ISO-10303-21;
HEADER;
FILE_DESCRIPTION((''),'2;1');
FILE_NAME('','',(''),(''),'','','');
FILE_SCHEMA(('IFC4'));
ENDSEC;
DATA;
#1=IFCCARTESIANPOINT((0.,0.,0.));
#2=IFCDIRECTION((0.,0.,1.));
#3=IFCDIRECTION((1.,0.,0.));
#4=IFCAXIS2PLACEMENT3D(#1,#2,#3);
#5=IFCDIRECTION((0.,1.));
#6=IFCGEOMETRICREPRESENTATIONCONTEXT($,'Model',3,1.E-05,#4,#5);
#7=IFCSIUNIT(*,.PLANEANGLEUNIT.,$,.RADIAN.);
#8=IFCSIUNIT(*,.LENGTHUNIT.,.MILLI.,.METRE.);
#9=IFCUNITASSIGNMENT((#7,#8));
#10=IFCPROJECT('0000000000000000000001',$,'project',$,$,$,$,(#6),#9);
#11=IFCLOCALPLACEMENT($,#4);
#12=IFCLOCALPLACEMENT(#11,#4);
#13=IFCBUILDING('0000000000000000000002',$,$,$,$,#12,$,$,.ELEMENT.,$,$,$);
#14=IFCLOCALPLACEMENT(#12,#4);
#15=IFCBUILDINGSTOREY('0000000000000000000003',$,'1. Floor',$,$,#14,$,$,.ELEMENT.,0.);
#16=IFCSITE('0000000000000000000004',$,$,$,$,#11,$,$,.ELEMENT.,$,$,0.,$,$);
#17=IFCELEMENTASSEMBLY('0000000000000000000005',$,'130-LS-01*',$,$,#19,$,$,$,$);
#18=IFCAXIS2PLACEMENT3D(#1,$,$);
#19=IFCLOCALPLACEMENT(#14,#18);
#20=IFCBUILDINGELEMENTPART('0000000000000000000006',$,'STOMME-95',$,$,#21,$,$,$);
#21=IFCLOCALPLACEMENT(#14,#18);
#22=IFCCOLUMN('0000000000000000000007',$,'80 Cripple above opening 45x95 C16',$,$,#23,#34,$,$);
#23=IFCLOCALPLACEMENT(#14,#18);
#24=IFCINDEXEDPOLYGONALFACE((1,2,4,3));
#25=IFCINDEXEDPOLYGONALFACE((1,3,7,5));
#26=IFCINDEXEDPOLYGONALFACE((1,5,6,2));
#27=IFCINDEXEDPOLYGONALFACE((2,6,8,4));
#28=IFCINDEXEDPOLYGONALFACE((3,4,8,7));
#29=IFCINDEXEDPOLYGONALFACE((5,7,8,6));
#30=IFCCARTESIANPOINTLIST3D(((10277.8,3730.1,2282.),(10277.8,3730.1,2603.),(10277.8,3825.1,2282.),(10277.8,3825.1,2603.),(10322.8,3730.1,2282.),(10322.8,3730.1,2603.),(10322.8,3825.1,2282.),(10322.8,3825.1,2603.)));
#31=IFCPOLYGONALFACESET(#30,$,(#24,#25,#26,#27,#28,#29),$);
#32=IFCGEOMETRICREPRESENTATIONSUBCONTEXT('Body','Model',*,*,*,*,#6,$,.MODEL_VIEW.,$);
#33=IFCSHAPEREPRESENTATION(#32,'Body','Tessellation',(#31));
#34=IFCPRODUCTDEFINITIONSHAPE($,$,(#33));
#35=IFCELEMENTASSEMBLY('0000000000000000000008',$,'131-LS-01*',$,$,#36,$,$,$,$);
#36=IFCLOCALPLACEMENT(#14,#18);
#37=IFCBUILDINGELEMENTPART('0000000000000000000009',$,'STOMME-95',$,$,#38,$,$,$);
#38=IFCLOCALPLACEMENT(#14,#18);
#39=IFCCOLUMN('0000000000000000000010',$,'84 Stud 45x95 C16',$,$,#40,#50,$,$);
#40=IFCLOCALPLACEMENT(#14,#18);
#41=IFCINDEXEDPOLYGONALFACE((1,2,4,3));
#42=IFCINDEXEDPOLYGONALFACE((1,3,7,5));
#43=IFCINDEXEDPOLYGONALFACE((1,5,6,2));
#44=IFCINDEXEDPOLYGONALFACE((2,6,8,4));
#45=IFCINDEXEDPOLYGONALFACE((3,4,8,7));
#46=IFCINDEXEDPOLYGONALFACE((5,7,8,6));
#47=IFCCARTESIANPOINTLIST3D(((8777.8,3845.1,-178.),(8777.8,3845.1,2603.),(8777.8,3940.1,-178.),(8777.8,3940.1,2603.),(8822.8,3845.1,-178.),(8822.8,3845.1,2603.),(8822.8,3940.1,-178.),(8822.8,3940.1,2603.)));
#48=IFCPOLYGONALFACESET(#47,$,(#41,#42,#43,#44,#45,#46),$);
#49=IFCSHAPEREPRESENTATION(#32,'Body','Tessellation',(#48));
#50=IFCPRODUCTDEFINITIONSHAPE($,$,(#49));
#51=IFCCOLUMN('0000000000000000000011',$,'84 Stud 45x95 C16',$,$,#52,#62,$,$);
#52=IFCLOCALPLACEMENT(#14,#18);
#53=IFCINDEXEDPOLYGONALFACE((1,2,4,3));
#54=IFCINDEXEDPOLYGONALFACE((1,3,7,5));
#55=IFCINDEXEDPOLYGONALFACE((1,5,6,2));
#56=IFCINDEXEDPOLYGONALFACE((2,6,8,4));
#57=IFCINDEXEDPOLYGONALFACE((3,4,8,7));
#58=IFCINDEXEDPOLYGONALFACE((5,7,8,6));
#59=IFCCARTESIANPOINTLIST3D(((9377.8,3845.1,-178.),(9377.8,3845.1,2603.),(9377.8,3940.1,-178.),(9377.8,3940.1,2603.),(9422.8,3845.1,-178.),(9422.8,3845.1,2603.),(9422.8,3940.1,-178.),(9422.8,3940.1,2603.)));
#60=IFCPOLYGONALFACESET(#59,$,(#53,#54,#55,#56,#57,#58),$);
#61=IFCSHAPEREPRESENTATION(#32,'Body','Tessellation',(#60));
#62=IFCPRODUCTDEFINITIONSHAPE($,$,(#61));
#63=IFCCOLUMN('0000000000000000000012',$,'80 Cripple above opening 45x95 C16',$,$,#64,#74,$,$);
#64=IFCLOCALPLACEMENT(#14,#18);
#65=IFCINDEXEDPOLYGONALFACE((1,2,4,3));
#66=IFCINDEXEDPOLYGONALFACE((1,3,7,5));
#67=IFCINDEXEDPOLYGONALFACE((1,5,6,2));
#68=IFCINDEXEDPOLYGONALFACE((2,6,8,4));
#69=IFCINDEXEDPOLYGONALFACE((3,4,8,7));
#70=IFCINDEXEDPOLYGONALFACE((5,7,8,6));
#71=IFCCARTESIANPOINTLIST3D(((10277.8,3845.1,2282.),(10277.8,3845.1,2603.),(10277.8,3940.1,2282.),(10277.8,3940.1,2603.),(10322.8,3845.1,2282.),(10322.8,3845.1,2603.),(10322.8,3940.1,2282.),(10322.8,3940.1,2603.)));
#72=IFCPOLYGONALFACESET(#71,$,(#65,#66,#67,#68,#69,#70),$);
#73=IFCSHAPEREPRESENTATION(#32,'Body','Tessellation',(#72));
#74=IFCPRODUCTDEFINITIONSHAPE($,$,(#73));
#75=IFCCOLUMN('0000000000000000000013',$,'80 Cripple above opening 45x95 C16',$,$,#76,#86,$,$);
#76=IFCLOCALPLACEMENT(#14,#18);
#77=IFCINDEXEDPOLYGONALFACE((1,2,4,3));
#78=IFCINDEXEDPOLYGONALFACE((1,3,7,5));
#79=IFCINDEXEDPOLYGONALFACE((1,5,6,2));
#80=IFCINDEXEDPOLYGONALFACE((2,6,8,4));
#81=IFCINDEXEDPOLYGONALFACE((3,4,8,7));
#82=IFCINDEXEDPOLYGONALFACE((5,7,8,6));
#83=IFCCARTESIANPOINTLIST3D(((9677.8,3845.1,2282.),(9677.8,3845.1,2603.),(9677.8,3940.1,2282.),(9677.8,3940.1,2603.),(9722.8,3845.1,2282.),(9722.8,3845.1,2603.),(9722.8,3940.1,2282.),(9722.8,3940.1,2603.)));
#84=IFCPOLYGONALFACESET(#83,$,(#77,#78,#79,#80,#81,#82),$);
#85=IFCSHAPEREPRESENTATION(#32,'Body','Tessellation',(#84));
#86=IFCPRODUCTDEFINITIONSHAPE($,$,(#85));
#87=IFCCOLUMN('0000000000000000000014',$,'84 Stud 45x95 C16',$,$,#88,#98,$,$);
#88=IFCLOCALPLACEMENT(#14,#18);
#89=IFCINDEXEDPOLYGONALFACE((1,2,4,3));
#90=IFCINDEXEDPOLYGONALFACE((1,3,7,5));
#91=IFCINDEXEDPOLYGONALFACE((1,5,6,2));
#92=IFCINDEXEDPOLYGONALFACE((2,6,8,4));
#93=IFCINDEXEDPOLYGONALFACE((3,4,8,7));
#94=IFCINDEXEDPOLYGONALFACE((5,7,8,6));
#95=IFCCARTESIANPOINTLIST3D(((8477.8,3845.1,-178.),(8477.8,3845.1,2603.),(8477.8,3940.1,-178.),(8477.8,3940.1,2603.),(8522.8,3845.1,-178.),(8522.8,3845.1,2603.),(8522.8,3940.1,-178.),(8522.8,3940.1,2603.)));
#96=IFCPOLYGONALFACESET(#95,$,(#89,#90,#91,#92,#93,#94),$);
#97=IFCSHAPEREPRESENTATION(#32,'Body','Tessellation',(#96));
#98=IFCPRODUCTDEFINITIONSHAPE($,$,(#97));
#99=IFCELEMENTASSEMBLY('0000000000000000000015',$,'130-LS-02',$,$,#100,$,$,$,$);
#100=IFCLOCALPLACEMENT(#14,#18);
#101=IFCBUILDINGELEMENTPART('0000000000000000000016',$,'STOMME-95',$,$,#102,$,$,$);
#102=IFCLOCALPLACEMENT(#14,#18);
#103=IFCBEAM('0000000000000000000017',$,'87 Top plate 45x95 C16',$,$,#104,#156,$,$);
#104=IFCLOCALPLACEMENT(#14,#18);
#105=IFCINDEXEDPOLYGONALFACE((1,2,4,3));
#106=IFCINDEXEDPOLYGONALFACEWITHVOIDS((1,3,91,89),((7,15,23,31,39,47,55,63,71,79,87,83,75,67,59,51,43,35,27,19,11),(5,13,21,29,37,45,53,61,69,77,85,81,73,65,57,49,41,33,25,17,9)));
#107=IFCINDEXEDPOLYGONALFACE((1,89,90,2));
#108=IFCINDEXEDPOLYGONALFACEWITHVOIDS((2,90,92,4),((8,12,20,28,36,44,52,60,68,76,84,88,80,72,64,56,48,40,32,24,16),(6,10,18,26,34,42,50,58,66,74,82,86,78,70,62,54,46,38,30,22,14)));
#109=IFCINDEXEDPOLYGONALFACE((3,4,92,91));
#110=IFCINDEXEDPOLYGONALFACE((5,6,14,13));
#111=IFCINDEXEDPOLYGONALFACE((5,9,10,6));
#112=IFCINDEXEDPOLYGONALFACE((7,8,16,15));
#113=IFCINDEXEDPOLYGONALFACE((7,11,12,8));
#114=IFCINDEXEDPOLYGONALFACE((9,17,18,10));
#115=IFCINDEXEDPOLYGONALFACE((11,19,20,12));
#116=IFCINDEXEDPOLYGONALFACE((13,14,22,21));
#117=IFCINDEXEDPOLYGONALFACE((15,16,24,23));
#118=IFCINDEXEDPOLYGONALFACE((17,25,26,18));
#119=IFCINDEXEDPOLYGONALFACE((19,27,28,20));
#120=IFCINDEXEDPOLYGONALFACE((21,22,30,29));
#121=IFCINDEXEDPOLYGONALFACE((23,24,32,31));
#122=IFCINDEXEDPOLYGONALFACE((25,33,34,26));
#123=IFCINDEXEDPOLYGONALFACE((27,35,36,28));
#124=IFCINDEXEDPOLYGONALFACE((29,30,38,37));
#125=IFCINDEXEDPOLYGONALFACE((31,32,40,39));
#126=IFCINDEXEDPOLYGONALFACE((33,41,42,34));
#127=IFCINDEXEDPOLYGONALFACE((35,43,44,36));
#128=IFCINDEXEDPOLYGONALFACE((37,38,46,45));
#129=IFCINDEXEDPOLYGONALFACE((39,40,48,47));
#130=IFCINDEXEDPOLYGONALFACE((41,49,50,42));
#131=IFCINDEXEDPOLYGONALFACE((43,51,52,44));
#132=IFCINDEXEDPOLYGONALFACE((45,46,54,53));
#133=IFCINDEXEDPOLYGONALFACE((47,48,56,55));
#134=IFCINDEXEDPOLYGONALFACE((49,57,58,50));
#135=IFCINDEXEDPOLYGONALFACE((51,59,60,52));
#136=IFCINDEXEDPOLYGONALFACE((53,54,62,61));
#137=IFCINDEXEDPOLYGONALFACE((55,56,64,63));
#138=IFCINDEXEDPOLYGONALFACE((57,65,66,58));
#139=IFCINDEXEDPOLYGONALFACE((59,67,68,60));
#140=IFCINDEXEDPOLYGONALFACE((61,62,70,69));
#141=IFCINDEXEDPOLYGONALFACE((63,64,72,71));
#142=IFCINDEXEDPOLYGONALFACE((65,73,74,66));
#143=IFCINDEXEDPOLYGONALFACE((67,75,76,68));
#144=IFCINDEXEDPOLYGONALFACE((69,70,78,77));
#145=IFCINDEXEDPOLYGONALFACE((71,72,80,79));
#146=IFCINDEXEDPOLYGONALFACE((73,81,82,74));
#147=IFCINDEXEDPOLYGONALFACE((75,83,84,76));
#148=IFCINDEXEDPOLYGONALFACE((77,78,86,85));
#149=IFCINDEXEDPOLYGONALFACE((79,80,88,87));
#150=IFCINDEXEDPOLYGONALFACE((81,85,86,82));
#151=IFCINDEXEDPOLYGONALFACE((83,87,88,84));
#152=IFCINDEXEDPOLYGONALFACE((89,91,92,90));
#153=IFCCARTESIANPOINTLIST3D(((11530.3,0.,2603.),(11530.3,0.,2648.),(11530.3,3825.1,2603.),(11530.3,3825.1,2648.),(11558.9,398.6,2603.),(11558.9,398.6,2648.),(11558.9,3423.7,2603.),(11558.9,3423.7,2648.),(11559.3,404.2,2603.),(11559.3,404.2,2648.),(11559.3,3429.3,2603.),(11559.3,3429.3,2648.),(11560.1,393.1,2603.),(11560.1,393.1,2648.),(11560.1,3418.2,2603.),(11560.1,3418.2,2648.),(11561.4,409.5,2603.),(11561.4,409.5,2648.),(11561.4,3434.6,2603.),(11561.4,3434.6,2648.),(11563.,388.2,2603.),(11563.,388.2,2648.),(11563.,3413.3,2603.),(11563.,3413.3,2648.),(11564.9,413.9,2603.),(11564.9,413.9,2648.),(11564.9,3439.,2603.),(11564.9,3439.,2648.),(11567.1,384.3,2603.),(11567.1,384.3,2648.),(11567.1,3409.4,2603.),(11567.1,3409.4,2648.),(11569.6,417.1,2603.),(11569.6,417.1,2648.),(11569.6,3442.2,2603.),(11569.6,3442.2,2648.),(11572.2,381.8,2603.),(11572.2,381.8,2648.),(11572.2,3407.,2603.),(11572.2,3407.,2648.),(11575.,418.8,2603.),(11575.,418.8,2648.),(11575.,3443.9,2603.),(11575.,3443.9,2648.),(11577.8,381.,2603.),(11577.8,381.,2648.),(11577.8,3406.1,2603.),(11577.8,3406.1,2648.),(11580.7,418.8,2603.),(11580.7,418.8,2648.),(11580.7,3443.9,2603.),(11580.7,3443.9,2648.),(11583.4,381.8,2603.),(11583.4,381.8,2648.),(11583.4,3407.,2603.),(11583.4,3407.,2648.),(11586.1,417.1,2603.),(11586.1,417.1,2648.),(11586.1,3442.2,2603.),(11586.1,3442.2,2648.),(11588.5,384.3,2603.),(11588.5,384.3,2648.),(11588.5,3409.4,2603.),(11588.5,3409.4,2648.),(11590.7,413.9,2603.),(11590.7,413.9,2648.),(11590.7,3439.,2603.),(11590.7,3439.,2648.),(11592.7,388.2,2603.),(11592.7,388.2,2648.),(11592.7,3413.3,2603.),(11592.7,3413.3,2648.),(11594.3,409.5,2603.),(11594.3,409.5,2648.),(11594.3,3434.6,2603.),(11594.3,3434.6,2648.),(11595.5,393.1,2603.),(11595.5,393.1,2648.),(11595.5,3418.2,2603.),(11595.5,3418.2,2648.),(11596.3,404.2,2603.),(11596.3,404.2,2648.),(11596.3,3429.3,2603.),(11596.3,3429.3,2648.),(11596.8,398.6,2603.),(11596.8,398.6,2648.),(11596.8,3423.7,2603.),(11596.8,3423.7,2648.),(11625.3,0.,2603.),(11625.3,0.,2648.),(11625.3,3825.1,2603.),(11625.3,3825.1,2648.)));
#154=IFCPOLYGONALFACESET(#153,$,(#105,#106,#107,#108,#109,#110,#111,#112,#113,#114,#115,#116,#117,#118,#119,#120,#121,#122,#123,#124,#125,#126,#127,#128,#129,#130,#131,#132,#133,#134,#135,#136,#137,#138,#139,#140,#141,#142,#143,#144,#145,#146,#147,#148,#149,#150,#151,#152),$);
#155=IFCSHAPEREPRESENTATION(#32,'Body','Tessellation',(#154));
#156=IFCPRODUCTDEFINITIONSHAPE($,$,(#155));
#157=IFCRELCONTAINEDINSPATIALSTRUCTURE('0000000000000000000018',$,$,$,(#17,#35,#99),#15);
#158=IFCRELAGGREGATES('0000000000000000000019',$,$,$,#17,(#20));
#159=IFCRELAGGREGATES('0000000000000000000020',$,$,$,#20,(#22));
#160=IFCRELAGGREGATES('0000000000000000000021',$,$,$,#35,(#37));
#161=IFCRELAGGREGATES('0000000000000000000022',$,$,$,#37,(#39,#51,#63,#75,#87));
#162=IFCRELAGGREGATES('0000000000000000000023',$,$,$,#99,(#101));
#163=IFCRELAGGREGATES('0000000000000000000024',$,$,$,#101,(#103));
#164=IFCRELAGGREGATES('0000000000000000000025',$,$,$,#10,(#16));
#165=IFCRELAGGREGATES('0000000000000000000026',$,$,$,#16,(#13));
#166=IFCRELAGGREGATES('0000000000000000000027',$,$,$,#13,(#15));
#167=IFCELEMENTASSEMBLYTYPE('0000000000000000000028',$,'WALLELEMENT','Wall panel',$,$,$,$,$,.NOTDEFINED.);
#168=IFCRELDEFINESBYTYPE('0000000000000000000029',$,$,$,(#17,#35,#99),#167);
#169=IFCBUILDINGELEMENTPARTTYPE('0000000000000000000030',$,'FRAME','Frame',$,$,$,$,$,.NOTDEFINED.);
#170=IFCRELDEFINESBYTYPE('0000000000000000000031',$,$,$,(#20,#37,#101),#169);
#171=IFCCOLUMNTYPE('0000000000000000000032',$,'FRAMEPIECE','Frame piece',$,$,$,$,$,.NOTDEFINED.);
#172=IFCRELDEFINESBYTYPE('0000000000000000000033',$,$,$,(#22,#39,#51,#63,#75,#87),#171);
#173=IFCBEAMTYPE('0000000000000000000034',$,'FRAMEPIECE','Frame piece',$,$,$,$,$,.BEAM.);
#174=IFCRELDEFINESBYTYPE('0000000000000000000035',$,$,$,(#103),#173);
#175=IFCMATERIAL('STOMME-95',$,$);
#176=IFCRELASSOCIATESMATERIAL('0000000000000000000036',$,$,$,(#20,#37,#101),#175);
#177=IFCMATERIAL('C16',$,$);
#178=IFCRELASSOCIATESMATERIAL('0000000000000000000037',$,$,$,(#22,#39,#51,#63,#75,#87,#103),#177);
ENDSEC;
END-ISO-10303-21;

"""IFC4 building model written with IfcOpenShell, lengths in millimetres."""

from ifc_helpers import new_model, si_unit, direction, frame, origin_with_axes, origin_2d_with_axis, place, context, subcontext, project, spatial, rectangle, circle, extrude, boolean, material, type_object, element, aggregate, save


model = new_model("IFC4")

# Units and contexts
model_context = context("Model", 3, precision=1e-05, world=origin_with_axes(), true_north=direction((0.0, 1.0)))
body_context = subcontext(model_context, "Body", "Model", "MODEL_VIEW")
ifc_project = project(units=[si_unit("PLANEANGLEUNIT", "RADIAN"), si_unit("LENGTHUNIT", "METRE", prefix="MILLI")], contexts=[model_context])

# Site, building, storey
site_placement = place(None, origin_with_axes())
site = spatial("IfcSite", under=ifc_project, at=site_placement, CompositionType="ELEMENT", RefElevation=0.0)
building_placement = place(site_placement, origin_with_axes())
building = spatial("IfcBuilding", under=site, at=building_placement, CompositionType="ELEMENT")
storey_placement = place(building_placement, origin_with_axes())
storey = spatial("IfcBuildingStorey", under=building, at=storey_placement, Name="1. Floor", CompositionType="ELEMENT", Elevation=0.0)

# Element assembly, building element part, column
element_assembly_type_1 = type_object("IfcElementAssemblyType", Name="WALLELEMENT", Description="Wall panel", PredefinedType="NOTDEFINED")
assembly_1_placement = place(storey_placement, origin_with_axes())
assembly_1 = element("IfcElementAssembly", 1, at=assembly_1_placement, inside=storey, type_object=element_assembly_type_1, Name="130-LS-01*")
ifc_material_1 = material(Name="STOMME-95")
building_element_part_type = type_object("IfcBuildingElementPartType", Name="FRAME", Description="Frame", PredefinedType="NOTDEFINED")
building_element_part_1_placement = place(storey_placement, origin_with_axes())
building_element_part_1 = element("IfcBuildingElementPart", 2, at=building_element_part_1_placement, type_object=building_element_part_type, material=ifc_material_1, Name="STOMME-95")
aggregate(assembly_1, [building_element_part_1])
ifc_material_2 = material(Name="C16")
column_type = type_object("IfcColumnType", Name="FRAMEPIECE", Description="Frame piece", PredefinedType="NOTDEFINED")
column_1_placement = place(storey_placement, frame((10300.3, 3777.6, 2603.0), z_axis=(0.0, 0.0, -1.0), x_axis=(-1.0, 0.0, 0.0)))
column_1 = element("IfcColumn", 3, at=column_1_placement, type_object=column_type, material=ifc_material_2, Name="80 Cripple above opening 45x95 C16", context=body_context, shape_type="SweptSolid", body=[
    extrude(rectangle(XDim=45.0, YDim=95.0, at=origin_2d_with_axis()), origin_with_axes(), (0.0, 0.0, 1.0), 321.0),
])
aggregate(building_element_part_1, [column_1])

# Element assembly, building element part, columns
assembly_2_placement = place(storey_placement, origin_with_axes())
assembly_2 = element("IfcElementAssembly", 4, at=assembly_2_placement, inside=storey, type_object=element_assembly_type_1, Name="131-LS-01*")
building_element_part_2_placement = place(storey_placement, origin_with_axes())
building_element_part_2 = element("IfcBuildingElementPart", 5, at=building_element_part_2_placement, type_object=building_element_part_type, material=ifc_material_1, Name="STOMME-95")
aggregate(assembly_2, [building_element_part_2])
column_2_placement = place(storey_placement, frame((8800.3, 3892.6, 2603.0), z_axis=(0.0, 0.0, -1.0), x_axis=(1.0, 0.0, 0.0)))
column_2 = element("IfcColumn", 6, at=column_2_placement, type_object=column_type, material=ifc_material_2, Name="84 Stud 45x95 C16", context=body_context, shape_type="SweptSolid", body=[
    extrude(rectangle(XDim=45.0, YDim=95.0, at=origin_2d_with_axis()), origin_with_axes(), (0.0, 0.0, 1.0), 2781.0),
])
column_3_placement = place(storey_placement, frame((9400.3, 3892.6, 2603.0), z_axis=(0.0, 0.0, -1.0), x_axis=(1.0, 0.0, 0.0)))
column_3 = element("IfcColumn", 7, at=column_3_placement, type_object=column_type, material=ifc_material_2, Name="84 Stud 45x95 C16", context=body_context, shape_type="SweptSolid", body=[
    extrude(rectangle(XDim=45.0, YDim=95.0, at=origin_2d_with_axis()), origin_with_axes(), (0.0, 0.0, 1.0), 2781.0),
])
column_4_placement = place(storey_placement, frame((10300.3, 3892.6, 2603.0), z_axis=(0.0, 0.0, -1.0), x_axis=(1.0, 0.0, 0.0)))
column_4 = element("IfcColumn", 8, at=column_4_placement, type_object=column_type, material=ifc_material_2, Name="80 Cripple above opening 45x95 C16", context=body_context, shape_type="SweptSolid", body=[
    extrude(rectangle(XDim=45.0, YDim=95.0, at=origin_2d_with_axis()), origin_with_axes(), (0.0, 0.0, 1.0), 321.0),
])
column_5_placement = place(storey_placement, frame((9700.3, 3892.6, 2603.0), z_axis=(0.0, 0.0, -1.0), x_axis=(1.0, 0.0, 0.0)))
column_5 = element("IfcColumn", 9, at=column_5_placement, type_object=column_type, material=ifc_material_2, Name="80 Cripple above opening 45x95 C16", context=body_context, shape_type="SweptSolid", body=[
    extrude(rectangle(XDim=45.0, YDim=95.0, at=origin_2d_with_axis()), origin_with_axes(), (0.0, 0.0, 1.0), 321.0),
])
column_6_placement = place(storey_placement, frame((8500.3, 3892.6, 2603.0), z_axis=(0.0, 0.0, -1.0), x_axis=(1.0, 0.0, 0.0)))
column_6 = element("IfcColumn", 10, at=column_6_placement, type_object=column_type, material=ifc_material_2, Name="84 Stud 45x95 C16", context=body_context, shape_type="SweptSolid", body=[
    extrude(rectangle(XDim=45.0, YDim=95.0, at=origin_2d_with_axis()), origin_with_axes(), (0.0, 0.0, 1.0), 2781.0),
])
beam_type = type_object("IfcBeamType", Name="FRAMEPIECE", Description="Frame piece", PredefinedType="BEAM")
aggregate(building_element_part_2, [column_2, column_3, column_4, column_5, column_6])

# Element assembly, building element part, beam
assembly_3_placement = place(storey_placement, origin_with_axes())
assembly_3 = element("IfcElementAssembly", 11, at=assembly_3_placement, inside=storey, type_object=element_assembly_type_1, Name="130-LS-02")
building_element_part_3_placement = place(storey_placement, origin_with_axes())
building_element_part_3 = element("IfcBuildingElementPart", 12, at=building_element_part_3_placement, type_object=building_element_part_type, material=ifc_material_1, Name="STOMME-95")
aggregate(assembly_3, [building_element_part_3])
beam_1_placement = place(storey_placement, frame((11577.8, 3825.1, 2625.5), z_axis=(0.0, -1.0, 0.0), x_axis=(0.0, 0.0, -1.0)))
beam_1 = element("IfcBeam", 13, at=beam_1_placement, type_object=beam_type, material=ifc_material_2, Name="87 Top plate 45x95 C16", context=body_context, shape_type="CSG", body=[
    boolean("DIFFERENCE", boolean("DIFFERENCE", extrude(rectangle(XDim=45.0, YDim=95.0, at=origin_2d_with_axis()), origin_with_axes(), (0.0, 0.0, 1.0), 3825.1), extrude(circle(Radius=19.0, at=origin_2d_with_axis()), frame((-45.0, 0.0, 400.0), z_axis=(-1.0, 0.0, 0.0), x_axis=(0.0, 0.0, 1.0)), (0.0, 0.0, -1.0), 90.0)), extrude(circle(Radius=19.0, at=origin_2d_with_axis()), frame((-45.0, 0.0, 3425.1), z_axis=(-1.0, 0.0, 0.0), x_axis=(0.0, 0.0, 1.0)), (0.0, 0.0, -1.0), 90.0)),
])
aggregate(building_element_part_3, [beam_1])

save(model, "model.ifc")
